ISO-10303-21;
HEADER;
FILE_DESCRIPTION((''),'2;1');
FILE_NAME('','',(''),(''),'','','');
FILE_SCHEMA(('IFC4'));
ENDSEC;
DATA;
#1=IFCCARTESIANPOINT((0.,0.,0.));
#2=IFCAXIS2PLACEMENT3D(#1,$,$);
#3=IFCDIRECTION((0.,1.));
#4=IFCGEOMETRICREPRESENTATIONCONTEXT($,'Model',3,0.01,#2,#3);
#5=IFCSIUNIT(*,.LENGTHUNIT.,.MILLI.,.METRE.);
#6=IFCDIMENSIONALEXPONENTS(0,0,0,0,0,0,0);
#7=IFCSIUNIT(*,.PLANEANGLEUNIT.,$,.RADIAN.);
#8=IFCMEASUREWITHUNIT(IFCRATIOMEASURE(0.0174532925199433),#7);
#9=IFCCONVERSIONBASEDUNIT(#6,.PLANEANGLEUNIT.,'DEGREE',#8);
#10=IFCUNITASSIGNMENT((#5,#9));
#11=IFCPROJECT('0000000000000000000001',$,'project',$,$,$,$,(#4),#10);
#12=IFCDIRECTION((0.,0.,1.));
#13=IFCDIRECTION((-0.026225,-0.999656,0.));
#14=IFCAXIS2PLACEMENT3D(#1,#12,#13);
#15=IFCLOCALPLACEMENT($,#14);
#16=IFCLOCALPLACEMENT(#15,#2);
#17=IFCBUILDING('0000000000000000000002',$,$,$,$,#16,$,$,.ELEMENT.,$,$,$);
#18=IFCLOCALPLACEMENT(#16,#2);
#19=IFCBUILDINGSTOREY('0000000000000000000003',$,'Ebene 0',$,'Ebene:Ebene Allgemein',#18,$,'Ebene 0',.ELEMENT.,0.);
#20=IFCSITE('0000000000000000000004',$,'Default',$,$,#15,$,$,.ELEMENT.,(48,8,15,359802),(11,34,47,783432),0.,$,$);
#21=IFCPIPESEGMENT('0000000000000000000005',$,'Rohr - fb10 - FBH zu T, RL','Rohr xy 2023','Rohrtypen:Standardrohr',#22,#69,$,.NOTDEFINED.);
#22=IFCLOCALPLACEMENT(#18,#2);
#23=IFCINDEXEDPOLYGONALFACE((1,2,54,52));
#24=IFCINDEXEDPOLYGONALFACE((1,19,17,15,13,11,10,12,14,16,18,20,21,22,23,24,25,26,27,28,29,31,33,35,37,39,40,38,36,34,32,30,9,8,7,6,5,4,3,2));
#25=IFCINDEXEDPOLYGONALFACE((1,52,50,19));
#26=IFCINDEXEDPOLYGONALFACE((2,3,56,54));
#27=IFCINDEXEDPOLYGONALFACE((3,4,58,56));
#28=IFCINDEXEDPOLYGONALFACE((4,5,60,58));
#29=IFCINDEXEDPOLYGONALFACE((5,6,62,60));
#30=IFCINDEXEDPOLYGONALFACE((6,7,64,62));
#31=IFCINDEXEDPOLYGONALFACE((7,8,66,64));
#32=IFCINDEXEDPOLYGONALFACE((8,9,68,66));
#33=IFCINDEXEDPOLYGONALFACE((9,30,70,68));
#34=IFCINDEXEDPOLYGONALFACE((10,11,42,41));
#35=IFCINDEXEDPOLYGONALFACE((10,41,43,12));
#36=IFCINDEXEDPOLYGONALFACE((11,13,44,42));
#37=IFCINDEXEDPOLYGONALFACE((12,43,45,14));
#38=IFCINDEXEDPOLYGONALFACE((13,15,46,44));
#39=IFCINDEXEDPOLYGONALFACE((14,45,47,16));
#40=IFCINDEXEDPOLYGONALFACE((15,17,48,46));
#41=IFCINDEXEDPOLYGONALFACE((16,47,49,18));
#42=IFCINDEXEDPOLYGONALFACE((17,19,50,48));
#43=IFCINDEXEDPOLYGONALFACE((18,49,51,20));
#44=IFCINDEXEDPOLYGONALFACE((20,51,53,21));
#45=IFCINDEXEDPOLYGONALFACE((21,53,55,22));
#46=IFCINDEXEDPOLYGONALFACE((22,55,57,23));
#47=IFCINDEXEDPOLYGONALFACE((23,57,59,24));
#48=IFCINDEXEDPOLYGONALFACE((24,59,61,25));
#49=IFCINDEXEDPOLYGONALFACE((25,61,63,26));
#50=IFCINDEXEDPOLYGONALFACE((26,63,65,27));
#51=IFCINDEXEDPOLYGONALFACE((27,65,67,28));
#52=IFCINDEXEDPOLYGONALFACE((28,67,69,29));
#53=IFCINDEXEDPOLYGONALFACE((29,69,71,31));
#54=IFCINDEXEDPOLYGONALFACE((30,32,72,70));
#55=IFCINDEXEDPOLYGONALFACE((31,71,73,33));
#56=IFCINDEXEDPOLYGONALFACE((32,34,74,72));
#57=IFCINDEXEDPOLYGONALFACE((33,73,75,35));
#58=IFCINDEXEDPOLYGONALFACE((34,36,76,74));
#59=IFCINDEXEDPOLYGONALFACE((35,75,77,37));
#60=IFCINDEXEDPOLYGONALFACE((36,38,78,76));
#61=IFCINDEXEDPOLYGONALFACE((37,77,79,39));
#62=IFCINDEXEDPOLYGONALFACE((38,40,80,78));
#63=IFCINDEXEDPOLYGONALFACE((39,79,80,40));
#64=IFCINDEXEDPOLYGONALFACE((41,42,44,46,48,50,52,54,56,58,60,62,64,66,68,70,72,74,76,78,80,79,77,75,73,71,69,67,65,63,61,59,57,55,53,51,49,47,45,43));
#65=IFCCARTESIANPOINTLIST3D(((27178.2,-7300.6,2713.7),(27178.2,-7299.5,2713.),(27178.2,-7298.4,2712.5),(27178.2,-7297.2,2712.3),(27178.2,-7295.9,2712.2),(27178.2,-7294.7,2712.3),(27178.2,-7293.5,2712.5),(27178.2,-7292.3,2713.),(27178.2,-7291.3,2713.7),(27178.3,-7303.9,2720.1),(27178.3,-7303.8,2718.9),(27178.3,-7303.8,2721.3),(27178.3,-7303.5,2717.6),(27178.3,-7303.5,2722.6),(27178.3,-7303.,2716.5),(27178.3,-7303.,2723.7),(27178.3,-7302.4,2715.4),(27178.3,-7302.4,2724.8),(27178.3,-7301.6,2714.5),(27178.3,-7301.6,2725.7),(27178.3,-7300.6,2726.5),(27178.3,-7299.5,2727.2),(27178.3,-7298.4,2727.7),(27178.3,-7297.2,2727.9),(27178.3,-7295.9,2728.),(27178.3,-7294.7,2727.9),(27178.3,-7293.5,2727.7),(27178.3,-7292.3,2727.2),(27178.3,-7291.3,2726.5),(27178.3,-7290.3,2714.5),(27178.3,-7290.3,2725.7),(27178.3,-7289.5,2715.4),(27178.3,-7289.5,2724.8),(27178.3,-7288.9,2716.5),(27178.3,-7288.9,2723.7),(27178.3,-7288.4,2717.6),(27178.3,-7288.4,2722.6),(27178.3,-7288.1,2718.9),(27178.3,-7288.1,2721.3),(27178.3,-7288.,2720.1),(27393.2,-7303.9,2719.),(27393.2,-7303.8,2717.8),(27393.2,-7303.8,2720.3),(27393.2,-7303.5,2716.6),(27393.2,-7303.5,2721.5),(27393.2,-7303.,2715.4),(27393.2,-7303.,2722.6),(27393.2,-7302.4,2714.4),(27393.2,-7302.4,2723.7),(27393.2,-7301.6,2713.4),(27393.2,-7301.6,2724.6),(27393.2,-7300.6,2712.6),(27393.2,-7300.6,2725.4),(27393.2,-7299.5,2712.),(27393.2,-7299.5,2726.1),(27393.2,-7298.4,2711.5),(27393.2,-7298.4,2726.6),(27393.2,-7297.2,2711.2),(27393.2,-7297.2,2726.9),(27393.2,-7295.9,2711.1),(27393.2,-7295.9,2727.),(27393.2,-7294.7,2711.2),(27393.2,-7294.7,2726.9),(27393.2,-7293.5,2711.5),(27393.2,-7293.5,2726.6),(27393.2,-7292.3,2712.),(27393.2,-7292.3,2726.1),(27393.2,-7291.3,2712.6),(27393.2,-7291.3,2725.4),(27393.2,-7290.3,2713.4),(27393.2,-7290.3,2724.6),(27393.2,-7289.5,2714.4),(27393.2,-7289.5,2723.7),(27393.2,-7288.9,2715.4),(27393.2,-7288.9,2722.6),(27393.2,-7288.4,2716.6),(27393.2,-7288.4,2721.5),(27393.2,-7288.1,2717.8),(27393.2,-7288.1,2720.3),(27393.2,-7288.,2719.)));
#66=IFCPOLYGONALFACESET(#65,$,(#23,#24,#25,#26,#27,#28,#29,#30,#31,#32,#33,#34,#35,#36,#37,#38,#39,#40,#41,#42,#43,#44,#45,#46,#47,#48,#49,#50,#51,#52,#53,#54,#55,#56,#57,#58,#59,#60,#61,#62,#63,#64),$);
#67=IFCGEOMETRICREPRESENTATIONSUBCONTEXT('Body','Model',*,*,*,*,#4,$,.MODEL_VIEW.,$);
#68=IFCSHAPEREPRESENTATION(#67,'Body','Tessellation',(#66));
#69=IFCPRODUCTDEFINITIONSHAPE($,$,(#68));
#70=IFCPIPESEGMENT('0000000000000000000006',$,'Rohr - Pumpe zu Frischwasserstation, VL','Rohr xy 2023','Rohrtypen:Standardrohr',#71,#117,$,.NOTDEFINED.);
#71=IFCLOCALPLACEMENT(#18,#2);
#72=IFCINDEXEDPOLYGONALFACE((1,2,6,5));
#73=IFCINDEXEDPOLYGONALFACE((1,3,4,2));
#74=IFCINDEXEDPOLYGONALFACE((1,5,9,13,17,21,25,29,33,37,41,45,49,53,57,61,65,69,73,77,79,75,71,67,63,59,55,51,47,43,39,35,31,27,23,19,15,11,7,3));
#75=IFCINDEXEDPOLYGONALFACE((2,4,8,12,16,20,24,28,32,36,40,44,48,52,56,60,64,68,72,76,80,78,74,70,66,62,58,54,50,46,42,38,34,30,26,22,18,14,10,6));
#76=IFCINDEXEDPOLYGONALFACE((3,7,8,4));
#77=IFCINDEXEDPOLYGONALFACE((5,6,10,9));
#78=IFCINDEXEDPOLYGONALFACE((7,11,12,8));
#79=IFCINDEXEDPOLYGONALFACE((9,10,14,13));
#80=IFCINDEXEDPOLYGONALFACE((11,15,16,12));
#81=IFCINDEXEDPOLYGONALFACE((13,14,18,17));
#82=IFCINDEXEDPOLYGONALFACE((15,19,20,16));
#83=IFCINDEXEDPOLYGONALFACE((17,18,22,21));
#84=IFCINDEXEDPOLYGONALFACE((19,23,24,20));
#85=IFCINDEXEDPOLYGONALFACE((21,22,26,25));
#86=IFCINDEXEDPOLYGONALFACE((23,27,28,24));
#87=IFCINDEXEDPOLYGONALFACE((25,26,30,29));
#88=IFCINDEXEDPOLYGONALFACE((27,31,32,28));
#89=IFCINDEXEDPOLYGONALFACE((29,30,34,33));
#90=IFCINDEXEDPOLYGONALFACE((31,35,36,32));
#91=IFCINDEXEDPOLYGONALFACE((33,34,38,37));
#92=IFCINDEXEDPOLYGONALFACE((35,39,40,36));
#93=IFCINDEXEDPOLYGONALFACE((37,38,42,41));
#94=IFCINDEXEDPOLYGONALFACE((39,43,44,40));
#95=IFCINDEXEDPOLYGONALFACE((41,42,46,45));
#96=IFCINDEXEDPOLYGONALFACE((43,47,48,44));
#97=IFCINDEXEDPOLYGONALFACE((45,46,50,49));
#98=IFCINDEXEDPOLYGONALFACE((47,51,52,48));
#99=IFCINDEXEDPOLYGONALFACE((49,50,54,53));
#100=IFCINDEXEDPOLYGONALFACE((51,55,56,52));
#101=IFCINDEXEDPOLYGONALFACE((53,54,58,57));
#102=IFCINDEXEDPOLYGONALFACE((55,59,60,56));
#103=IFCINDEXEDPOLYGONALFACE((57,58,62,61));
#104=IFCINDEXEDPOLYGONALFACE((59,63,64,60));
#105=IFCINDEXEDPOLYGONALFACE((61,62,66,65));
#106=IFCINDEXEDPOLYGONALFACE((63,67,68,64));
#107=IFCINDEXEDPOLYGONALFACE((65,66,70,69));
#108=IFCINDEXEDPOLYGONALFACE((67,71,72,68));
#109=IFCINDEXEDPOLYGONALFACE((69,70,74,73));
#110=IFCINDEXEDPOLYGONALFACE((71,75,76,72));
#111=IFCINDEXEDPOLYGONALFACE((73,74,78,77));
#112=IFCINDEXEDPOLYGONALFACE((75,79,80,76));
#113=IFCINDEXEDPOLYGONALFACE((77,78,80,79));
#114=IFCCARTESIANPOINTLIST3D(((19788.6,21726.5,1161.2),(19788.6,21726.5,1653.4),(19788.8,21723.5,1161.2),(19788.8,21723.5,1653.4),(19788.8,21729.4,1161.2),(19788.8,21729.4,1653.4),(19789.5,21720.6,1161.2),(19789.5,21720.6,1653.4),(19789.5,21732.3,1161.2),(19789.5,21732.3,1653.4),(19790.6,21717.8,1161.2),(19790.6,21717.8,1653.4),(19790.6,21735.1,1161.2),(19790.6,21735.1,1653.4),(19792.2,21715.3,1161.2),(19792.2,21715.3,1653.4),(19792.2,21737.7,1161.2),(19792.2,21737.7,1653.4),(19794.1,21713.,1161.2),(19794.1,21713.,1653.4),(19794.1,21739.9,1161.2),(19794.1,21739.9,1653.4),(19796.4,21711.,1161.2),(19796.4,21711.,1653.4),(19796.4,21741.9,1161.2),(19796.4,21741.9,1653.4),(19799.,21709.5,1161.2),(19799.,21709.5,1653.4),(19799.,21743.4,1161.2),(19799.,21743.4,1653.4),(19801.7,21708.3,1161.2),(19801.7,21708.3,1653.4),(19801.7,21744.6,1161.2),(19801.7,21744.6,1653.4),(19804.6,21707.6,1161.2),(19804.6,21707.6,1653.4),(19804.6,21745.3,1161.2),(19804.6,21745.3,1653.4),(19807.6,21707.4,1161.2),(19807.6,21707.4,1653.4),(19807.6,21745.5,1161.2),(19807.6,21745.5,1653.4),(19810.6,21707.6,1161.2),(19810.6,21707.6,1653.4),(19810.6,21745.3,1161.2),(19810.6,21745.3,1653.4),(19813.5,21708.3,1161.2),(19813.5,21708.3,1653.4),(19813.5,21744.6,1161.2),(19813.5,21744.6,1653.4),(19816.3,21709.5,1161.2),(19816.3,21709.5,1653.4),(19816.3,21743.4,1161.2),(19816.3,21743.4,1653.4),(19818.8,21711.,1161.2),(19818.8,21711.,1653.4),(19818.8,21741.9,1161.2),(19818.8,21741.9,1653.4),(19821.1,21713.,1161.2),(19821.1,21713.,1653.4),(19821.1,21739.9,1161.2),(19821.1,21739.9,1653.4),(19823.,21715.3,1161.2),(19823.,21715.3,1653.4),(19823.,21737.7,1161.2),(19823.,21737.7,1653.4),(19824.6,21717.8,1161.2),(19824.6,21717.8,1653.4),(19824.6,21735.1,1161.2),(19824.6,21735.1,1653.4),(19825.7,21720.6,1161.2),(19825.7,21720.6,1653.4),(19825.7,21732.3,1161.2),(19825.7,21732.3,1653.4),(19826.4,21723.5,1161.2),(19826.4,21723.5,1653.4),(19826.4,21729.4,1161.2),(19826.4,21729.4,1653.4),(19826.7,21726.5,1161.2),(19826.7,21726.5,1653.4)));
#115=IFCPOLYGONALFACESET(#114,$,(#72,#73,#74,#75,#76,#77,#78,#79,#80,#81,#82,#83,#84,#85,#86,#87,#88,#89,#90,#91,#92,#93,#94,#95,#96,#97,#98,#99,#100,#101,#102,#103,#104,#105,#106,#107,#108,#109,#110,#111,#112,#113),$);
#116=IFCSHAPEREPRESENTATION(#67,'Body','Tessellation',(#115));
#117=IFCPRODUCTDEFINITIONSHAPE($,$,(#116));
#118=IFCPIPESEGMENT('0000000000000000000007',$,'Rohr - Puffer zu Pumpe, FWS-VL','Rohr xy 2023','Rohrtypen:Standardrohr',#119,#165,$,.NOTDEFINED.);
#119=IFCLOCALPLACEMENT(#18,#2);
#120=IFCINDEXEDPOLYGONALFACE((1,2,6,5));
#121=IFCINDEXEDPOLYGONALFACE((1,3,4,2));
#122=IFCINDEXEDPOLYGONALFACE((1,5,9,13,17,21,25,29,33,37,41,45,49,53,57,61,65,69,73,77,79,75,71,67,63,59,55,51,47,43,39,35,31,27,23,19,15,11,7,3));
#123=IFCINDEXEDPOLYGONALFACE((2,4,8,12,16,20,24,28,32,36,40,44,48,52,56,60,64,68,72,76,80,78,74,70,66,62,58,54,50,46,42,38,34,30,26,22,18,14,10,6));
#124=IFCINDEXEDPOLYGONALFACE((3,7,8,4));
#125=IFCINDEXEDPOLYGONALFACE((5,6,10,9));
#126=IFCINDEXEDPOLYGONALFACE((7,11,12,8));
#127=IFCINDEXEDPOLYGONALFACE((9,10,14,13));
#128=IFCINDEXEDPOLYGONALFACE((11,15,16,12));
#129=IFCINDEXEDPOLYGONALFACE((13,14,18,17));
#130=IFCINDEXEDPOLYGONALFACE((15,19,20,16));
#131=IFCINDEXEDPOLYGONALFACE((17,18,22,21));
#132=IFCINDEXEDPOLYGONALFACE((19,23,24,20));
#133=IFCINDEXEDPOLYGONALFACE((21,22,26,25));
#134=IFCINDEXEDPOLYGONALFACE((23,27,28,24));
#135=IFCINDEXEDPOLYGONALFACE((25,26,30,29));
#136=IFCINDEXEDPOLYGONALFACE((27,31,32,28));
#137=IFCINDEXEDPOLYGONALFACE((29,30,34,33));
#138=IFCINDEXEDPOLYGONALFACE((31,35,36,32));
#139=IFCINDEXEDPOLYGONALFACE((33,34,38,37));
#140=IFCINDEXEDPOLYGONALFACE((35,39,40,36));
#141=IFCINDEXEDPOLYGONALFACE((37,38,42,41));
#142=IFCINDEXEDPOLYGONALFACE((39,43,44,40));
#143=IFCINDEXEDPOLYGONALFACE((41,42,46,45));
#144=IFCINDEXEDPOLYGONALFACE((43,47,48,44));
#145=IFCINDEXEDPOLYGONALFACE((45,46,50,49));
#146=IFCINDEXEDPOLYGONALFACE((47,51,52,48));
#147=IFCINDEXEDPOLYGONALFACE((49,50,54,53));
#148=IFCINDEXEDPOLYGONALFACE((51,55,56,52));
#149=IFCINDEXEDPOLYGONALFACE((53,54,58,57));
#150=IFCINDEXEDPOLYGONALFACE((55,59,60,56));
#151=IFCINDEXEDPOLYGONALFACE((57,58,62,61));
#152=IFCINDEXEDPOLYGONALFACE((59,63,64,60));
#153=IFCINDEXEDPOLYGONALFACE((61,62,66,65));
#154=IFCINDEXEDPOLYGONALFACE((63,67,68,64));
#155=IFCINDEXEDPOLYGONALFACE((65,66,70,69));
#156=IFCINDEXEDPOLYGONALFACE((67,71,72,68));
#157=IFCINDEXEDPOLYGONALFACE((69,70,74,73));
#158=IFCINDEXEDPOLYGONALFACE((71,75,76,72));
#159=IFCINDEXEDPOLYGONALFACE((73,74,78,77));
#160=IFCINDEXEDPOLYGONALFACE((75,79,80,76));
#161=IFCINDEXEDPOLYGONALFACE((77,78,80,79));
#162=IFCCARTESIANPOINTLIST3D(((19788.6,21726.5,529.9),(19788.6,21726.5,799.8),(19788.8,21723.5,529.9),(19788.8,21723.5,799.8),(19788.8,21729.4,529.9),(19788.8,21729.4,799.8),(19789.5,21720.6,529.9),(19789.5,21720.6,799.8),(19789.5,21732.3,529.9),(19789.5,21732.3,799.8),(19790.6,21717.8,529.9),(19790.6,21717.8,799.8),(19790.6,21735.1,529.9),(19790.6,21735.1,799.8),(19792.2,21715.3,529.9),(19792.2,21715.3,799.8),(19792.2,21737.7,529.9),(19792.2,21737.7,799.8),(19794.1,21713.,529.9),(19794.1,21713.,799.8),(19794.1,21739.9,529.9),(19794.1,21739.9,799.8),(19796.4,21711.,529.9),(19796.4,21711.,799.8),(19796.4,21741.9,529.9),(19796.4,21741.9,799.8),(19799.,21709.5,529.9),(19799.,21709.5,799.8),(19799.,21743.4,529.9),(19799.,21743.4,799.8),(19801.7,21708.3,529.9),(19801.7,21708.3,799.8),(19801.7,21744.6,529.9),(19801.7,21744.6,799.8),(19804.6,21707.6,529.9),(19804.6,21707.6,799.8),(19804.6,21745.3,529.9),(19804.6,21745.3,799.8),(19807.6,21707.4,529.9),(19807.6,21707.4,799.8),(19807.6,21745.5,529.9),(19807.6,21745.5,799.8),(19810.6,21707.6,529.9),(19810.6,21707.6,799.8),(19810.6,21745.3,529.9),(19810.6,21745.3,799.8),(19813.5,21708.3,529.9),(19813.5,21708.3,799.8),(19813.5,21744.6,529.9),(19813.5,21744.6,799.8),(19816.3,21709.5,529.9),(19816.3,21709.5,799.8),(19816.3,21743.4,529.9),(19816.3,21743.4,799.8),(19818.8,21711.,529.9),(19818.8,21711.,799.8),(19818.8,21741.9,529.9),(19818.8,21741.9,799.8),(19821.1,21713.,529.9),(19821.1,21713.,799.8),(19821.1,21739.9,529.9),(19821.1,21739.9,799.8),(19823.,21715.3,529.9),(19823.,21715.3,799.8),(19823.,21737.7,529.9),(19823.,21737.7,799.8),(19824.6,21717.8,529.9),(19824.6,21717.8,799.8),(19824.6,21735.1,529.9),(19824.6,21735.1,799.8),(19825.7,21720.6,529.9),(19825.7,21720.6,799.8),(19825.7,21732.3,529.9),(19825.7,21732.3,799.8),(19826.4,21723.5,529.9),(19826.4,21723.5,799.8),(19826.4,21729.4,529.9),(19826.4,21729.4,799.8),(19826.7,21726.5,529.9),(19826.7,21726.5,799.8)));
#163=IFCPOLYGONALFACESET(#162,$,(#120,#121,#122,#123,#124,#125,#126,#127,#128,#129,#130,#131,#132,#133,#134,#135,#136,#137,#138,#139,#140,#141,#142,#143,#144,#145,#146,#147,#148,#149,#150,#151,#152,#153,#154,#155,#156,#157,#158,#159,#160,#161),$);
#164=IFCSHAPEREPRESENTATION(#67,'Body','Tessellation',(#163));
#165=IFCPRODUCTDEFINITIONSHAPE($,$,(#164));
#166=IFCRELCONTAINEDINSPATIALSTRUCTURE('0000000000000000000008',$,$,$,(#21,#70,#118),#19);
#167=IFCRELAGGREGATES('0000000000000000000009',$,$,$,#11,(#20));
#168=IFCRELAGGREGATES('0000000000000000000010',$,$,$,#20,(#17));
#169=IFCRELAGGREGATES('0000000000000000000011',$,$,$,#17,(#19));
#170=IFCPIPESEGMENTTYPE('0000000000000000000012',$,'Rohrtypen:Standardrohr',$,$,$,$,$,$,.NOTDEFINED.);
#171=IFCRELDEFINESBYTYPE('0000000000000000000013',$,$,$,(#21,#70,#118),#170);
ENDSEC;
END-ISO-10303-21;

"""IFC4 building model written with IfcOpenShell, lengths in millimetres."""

from ifc_helpers import new_model, entity, si_unit, converted_unit, direction, frame, origin, place, context, subcontext, project, spatial, indexed_curve, outline, extrude, type_object, element, save


model = new_model("IFC4")

# Units and contexts
model_context = context("Model", 3, precision=0.01, world=origin(), true_north=direction((0.0, 1.0)))
body_context = subcontext(model_context, "Body", "Model", "MODEL_VIEW")
ifc_project = project(units=[si_unit("LENGTHUNIT", "METRE", prefix="MILLI"), converted_unit("PLANEANGLEUNIT", "DEGREE", entity("IfcRatioMeasure", 0.0174532925199433), si_unit("PLANEANGLEUNIT", "RADIAN"), dimensions=[0, 0, 0, 0, 0, 0, 0])], contexts=[model_context])

# Site, building, storey
site_placement = place(None, frame((0.0, 0.0, 0.0), z_axis=(0.0, 0.0, 1.0), x_axis=(-0.026225, -0.999656, 0.0)))
site = spatial("IfcSite", under=ifc_project, at=site_placement, Name="Default", CompositionType="ELEMENT", RefLatitude=(48, 8, 15, 359802), RefLongitude=(11, 34, 47, 783432), RefElevation=0.0)
building_placement = place(site_placement, origin())
building = spatial("IfcBuilding", under=site, at=building_placement, CompositionType="ELEMENT")
storey_placement = place(building_placement, origin())
storey = spatial("IfcBuildingStorey", under=building, at=storey_placement, Name="Ebene 0", ObjectType="Ebene:Ebene Allgemein", LongName="Ebene 0", CompositionType="ELEMENT", Elevation=0.0)

# Pipe segments
pipe_segment_type = type_object("IfcPipeSegmentType", Name="Rohrtypen:Standardrohr", PredefinedType="NOTDEFINED")
pipe_segment_1_placement = place(storey_placement, origin())
element("IfcPipeSegment", 1, at=pipe_segment_1_placement, inside=storey, type_object=pipe_segment_type, Name="Rohr - fb10 - FBH zu T, RL", Description="Rohr xy 2023", ObjectType="Rohrtypen:Standardrohr", PredefinedType="NOTDEFINED", context=body_context, shape_type="SweptSolid", body=[
    extrude(outline(indexed_curve([(7.9, 0.0), (7.8, 1.2), (7.6, 2.5), (7.1, 3.6), (6.4, 4.7), (5.6, 5.6), (4.7, 6.4), (3.6, 7.1), (2.5, 7.6), (1.2, 7.8), (0.0, 7.9), (-1.2, 7.8), (-2.5, 7.6), (-3.6, 7.1), (-4.7, 6.4), (-5.6, 5.6), (-6.4, 4.7), (-7.1, 3.6), (-7.6, 2.5), (-7.8, 1.2), (-7.9, 0.0), (-7.8, -1.2), (-7.6, -2.5), (-7.1, -3.6), (-6.4, -4.7), (-5.6, -5.6), (-4.7, -6.4), (-3.6, -7.1), (-2.5, -7.6), (-1.2, -7.8), (0.0, -7.9), (1.2, -7.8), (2.5, -7.6), (3.6, -7.1), (4.7, -6.4), (5.6, -5.6), (6.4, -4.7), (7.1, -3.6), (7.6, -2.5), (7.8, -1.2), (7.9, 0.0)], self_intersect=False)), frame((27393.2, -7295.9, 2719.0), z_axis=(-0.999988, 0.0, 0.005), x_axis=(0.0, 1.0, 0.0)), (0.0, 0.0, 1.0), 214.9),
])
pipe_segment_2_placement = place(storey_placement, origin())
element("IfcPipeSegment", 2, at=pipe_segment_2_placement, inside=storey, type_object=pipe_segment_type, Name="Rohr - Pumpe zu Frischwasserstation, VL", Description="Rohr xy 2023", ObjectType="Rohrtypen:Standardrohr", PredefinedType="NOTDEFINED", context=body_context, shape_type="SweptSolid", body=[
    extrude(outline(indexed_curve([(19.1, 0.0), (18.8, 3.0), (18.1, 5.9), (17.0, 8.6), (15.4, 11.2), (13.5, 13.5), (11.2, 15.4), (8.6, 17.0), (5.9, 18.1), (3.0, 18.8), (0.0, 19.0), (-3.0, 18.8), (-5.9, 18.1), (-8.6, 17.0), (-11.2, 15.4), (-13.5, 13.5), (-15.4, 11.2), (-17.0, 8.6), (-18.1, 5.9), (-18.8, 3.0), (-19.1, 0.0), (-18.8, -3.0), (-18.1, -5.9), (-17.0, -8.6), (-15.4, -11.2), (-13.5, -13.5), (-11.2, -15.4), (-8.6, -17.0), (-5.9, -18.1), (-3.0, -18.8), (0.0, -19.0), (3.0, -18.8), (5.9, -18.1), (8.6, -17.0), (11.2, -15.4), (13.5, -13.5), (15.4, -11.2), (17.0, -8.6), (18.1, -5.9), (18.8, -3.0), (19.1, 0.0)], self_intersect=False)), frame((19807.6, 21726.5, 1161.2), z_axis=(0.000002, 0.000002, 1.0), x_axis=(-1.0, 0.0, 0.000002)), (0.0, 0.0, 1.0), 492.1),
])
pipe_segment_3_placement = place(storey_placement, origin())
element("IfcPipeSegment", 3, at=pipe_segment_3_placement, inside=storey, type_object=pipe_segment_type, Name="Rohr - Puffer zu Pumpe, FWS-VL", Description="Rohr xy 2023", ObjectType="Rohrtypen:Standardrohr", PredefinedType="NOTDEFINED", context=body_context, shape_type="SweptSolid", body=[
    extrude(outline(indexed_curve([(19.1, 0.0), (18.8, 3.0), (18.1, 5.9), (17.0, 8.6), (15.4, 11.2), (13.5, 13.5), (11.2, 15.4), (8.6, 17.0), (5.9, 18.1), (3.0, 18.8), (0.0, 19.0), (-3.0, 18.8), (-5.9, 18.1), (-8.6, 17.0), (-11.2, 15.4), (-13.5, 13.5), (-15.4, 11.2), (-17.0, 8.6), (-18.1, 5.9), (-18.8, 3.0), (-19.1, 0.0), (-18.8, -3.0), (-18.1, -5.9), (-17.0, -8.6), (-15.4, -11.2), (-13.5, -13.5), (-11.2, -15.4), (-8.6, -17.0), (-5.9, -18.1), (-3.0, -18.8), (0.0, -19.0), (3.0, -18.8), (5.9, -18.1), (8.6, -17.0), (11.2, -15.4), (13.5, -13.5), (15.4, -11.2), (17.0, -8.6), (18.1, -5.9), (18.8, -3.0), (19.1, 0.0)], self_intersect=False)), frame((19807.6, 21726.5, 529.9), z_axis=(0.000002, 0.000002, 1.0), x_axis=(-1.0, 0.0, 0.000002)), (0.0, 0.0, 1.0), 269.9),
])

save(model, "model.ifc")
